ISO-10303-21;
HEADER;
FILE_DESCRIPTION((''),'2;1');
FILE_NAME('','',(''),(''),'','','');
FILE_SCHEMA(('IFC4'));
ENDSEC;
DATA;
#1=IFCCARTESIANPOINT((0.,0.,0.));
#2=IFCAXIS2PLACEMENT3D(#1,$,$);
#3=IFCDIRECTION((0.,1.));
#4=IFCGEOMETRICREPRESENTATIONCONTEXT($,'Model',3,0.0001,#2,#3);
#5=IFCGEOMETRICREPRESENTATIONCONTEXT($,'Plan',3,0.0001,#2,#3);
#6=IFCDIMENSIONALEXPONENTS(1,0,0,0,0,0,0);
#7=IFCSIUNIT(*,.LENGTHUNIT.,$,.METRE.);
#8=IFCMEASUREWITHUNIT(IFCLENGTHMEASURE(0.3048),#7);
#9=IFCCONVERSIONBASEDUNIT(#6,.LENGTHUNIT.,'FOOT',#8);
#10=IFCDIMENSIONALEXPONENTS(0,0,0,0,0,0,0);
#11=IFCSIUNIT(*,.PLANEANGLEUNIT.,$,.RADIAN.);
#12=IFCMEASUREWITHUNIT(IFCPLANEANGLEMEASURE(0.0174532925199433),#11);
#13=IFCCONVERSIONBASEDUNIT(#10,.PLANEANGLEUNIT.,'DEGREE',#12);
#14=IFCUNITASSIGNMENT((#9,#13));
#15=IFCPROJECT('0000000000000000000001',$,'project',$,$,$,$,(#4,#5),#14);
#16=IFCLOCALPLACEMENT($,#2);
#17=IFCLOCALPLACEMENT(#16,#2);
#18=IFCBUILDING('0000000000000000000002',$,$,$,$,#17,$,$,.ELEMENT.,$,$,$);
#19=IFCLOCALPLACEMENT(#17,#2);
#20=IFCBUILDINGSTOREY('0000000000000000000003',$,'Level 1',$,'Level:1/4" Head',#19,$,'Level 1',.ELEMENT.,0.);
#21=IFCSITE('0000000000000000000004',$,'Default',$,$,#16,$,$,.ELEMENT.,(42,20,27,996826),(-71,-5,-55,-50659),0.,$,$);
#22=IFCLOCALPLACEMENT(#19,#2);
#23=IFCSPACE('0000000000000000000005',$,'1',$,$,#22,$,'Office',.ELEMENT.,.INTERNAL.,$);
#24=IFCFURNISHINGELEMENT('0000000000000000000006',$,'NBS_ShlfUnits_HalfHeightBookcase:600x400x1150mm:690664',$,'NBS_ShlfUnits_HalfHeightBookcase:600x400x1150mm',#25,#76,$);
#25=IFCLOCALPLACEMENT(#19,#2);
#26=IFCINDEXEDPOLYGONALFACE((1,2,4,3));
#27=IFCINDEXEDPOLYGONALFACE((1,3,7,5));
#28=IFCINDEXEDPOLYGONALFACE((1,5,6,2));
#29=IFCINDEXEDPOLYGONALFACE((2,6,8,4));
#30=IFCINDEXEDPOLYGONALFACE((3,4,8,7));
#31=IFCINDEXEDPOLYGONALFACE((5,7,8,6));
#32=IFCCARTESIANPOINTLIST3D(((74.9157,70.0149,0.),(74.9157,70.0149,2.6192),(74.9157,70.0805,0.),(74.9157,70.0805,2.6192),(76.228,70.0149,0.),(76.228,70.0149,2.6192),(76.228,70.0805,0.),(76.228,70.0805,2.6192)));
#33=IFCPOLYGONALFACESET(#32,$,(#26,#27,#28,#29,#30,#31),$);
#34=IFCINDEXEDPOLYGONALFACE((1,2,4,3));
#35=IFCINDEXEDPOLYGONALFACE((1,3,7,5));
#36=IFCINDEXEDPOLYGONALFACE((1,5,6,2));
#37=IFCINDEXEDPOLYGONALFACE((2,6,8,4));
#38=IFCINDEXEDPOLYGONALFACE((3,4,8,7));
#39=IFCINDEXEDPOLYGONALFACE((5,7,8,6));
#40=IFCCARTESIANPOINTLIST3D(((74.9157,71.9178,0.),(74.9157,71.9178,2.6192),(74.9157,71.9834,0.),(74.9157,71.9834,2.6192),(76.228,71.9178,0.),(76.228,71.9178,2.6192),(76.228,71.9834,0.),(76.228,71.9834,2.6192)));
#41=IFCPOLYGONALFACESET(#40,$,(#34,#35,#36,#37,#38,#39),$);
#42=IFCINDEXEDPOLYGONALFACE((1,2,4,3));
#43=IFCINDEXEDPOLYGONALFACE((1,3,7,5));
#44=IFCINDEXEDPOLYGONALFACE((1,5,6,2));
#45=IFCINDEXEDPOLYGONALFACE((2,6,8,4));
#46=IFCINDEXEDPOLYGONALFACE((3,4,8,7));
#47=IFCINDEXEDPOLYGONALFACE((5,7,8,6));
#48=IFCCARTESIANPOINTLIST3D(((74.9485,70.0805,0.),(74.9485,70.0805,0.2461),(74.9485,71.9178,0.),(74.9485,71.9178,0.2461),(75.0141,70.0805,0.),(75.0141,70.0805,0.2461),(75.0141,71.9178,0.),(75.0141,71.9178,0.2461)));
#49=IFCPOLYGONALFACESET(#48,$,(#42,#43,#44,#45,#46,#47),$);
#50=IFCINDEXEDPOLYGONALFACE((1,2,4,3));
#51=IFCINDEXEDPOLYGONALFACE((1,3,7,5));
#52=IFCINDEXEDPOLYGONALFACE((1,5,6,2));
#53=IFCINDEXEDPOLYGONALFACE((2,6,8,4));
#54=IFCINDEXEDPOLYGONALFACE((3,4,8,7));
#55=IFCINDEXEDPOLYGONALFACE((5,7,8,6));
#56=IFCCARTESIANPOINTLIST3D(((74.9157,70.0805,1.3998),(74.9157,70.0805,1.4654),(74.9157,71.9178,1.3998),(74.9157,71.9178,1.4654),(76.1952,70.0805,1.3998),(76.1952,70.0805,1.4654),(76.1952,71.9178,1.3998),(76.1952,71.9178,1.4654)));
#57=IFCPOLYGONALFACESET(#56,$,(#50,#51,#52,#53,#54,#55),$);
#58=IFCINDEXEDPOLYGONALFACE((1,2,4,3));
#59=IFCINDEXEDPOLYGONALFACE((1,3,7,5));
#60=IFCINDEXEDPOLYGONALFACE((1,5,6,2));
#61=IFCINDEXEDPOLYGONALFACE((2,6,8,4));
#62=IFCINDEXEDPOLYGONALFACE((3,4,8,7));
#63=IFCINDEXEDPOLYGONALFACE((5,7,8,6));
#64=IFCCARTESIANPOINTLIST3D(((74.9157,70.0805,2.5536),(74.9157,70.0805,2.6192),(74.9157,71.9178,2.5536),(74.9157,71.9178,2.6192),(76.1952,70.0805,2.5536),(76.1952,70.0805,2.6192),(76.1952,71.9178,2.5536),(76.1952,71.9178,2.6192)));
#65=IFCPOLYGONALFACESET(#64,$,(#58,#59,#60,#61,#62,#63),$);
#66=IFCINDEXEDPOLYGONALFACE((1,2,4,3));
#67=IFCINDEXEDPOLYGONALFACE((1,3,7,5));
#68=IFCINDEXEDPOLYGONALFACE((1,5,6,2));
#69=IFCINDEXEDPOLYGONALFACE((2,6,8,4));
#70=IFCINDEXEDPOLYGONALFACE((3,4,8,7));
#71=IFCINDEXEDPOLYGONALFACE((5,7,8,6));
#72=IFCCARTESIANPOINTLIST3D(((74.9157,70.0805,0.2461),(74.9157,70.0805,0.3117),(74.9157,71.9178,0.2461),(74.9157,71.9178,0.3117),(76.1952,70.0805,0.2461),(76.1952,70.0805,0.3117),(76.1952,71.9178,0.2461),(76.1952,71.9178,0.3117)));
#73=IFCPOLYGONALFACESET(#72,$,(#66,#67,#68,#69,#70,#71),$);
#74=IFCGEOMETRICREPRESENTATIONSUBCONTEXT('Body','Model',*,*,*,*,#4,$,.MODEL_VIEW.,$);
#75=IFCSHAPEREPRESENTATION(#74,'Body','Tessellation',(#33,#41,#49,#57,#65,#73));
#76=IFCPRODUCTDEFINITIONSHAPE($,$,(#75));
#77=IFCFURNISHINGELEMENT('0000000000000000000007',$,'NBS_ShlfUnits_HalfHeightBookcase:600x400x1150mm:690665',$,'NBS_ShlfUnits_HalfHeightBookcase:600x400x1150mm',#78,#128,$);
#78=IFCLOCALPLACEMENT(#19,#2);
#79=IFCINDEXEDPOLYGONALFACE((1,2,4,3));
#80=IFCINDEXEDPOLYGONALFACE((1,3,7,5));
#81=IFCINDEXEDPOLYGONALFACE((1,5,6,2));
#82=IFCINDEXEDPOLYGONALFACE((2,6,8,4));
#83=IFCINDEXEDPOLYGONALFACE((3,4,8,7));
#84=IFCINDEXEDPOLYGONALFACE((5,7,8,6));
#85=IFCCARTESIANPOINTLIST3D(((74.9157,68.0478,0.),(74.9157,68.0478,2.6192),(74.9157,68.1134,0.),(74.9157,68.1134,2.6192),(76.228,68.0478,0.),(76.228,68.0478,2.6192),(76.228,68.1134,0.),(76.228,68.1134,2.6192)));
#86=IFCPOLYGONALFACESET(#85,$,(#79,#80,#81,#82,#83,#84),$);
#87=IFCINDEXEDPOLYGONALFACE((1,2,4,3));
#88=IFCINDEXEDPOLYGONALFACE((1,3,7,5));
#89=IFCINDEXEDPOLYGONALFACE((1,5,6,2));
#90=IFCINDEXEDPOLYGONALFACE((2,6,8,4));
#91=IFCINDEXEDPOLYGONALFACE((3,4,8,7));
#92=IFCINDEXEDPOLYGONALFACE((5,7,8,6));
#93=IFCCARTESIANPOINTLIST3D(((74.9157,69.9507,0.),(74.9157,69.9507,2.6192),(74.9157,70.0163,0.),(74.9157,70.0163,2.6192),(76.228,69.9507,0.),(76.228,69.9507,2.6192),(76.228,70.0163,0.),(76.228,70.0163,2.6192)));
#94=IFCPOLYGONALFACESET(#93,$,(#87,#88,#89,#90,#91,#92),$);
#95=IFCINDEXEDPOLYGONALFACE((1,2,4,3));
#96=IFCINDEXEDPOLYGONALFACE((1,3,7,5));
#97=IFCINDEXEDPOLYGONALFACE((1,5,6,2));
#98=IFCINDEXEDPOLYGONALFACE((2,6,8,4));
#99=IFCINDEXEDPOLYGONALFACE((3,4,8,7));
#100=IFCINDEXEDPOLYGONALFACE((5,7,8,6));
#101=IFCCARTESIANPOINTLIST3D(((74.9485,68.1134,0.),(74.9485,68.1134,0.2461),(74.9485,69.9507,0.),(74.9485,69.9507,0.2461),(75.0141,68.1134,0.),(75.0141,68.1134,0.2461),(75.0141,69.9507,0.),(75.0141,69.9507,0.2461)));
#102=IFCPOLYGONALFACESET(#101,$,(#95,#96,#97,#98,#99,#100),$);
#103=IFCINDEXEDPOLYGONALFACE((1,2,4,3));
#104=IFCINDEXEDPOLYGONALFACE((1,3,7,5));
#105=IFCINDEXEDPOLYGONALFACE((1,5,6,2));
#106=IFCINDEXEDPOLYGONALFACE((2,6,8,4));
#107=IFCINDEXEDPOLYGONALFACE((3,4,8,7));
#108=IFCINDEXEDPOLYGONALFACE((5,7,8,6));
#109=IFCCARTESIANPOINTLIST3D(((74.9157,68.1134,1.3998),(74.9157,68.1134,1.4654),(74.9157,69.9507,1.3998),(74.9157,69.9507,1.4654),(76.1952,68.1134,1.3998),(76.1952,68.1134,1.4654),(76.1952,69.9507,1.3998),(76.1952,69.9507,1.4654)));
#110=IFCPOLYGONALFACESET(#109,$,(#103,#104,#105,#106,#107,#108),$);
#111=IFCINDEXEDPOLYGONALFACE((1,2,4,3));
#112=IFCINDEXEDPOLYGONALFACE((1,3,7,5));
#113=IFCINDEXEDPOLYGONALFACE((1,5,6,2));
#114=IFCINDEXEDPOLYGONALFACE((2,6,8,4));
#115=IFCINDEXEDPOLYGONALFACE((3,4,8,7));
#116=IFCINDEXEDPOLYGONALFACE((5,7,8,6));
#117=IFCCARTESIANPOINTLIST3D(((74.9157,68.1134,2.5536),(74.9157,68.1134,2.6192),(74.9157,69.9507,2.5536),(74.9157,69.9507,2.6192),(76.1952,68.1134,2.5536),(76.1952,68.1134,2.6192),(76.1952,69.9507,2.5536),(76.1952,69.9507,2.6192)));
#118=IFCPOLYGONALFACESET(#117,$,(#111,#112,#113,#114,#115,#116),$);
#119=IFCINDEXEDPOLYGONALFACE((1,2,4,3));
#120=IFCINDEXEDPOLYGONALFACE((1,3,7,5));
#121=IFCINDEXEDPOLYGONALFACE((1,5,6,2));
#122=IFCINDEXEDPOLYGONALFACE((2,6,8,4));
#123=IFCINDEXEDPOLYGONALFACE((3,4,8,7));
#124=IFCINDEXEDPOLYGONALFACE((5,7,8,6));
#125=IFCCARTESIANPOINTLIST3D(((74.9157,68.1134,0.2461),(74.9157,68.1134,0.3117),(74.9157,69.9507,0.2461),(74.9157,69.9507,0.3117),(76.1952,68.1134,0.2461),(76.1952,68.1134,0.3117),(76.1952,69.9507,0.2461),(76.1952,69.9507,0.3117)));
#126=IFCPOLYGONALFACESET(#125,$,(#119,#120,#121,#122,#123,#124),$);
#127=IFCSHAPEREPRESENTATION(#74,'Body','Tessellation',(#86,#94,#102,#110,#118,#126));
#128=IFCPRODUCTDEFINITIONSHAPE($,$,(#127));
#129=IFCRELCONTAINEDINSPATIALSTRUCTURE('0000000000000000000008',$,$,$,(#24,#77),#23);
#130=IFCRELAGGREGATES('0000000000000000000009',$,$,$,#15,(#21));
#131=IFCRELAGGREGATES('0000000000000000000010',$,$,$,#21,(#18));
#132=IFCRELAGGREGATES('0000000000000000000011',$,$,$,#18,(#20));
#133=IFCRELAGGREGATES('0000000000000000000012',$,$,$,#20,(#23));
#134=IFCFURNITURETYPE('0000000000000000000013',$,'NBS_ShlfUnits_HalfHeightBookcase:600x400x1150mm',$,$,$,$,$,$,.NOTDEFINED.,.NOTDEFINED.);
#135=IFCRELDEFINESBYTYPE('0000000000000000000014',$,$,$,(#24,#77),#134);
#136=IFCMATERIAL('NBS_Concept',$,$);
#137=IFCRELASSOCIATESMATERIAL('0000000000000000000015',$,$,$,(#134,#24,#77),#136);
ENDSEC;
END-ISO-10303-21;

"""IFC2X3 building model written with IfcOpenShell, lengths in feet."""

from ifc_helpers import new_model, entity, si_unit, converted_unit, direction, frame, frame_2d, origin, origin_2d_with_axis, place, context, subcontext, project, spatial, rectangle, extrude, source, transform, mapped, material, type_object, type_shapes, element, save


model = new_model("IFC2X3")

# Units and contexts
model_context = context("Model", 3, precision=0.0001, world=origin(), true_north=direction((0.0, 1.0)))
plan_context = context("Plan", 3, precision=0.0001, world=origin(), true_north=direction((0.0, 1.0)))
body_context = subcontext(model_context, "Body", "Model", "MODEL_VIEW")
ifc_project = project(units=[converted_unit("LENGTHUNIT", "FOOT", entity("IfcLengthMeasure", 0.3048), si_unit("LENGTHUNIT", "METRE"), dimensions=[1, 0, 0, 0, 0, 0, 0]), converted_unit("PLANEANGLEUNIT", "DEGREE", entity("IfcPlaneAngleMeasure", 0.0174532925199433), si_unit("PLANEANGLEUNIT", "RADIAN"), dimensions=[0, 0, 0, 0, 0, 0, 0])], contexts=[model_context, plan_context])

# Site, building, storey
site_placement = place(None, origin())
site = spatial("IfcSite", under=ifc_project, at=site_placement, Name="Default", CompositionType="ELEMENT", RefLatitude=(42, 20, 27, 996826), RefLongitude=(-71, -5, -55, -50659), RefElevation=0.0)
building_placement = place(site_placement, origin())
building = spatial("IfcBuilding", under=site, at=building_placement, CompositionType="ELEMENT")
storey_placement = place(building_placement, origin())
storey = spatial("IfcBuildingStorey", under=building, at=storey_placement, Name="Level 1", ObjectType="Level:1/4\" Head", LongName="Level 1", CompositionType="ELEMENT", Elevation=0.0)

# Shared definitions
space_1_placement = place(storey_placement, origin())
space_1 = spatial("IfcSpace", under=storey, at=space_1_placement, Name="1", LongName="Office", CompositionType="ELEMENT", InteriorOrExteriorSpace="INTERNAL")

# Furnishing elements
ifc_material_1 = material(Name="NBS_Concept")
furniture_type_1 = type_object("IfcFurnitureType", Name="NBS_ShlfUnits_HalfHeightBookcase:600x400x1150mm", AssemblyPlace="NOTDEFINED", material=ifc_material_1)
shared_shape_1 = source(origin(), body_context, "Body", "SweptSolid", [
    extrude(rectangle(XDim=0.0656, YDim=1.3123, at=origin_2d_with_axis()), frame((0.9514, -0.6562, 0.0), z_axis=(0.0, 0.0, 1.0), x_axis=(-1.0, 0.0, 0.0)), (0.0, 0.0, 1.0), 2.6192),
    extrude(rectangle(XDim=0.0656, YDim=1.3123, at=origin_2d_with_axis()), frame((-0.9514, -0.6562, 0.0), z_axis=(0.0, 0.0, 1.0), x_axis=(-1.0, 0.0, 0.0)), (0.0, 0.0, 1.0), 2.6192),
    extrude(rectangle(XDim=1.8373, YDim=0.0656, at=origin_2d_with_axis()), frame((0.0, -1.2467, 0.0), z_axis=(0.0, 0.0, 1.0), x_axis=(-1.0, 0.0, 0.0)), (0.0, 0.0, 1.0), 0.2461),
    extrude(rectangle(XDim=1.2795, YDim=1.8373, at=frame_2d((0.0, 0.0), x_axis=(1.0, 0.0))), frame((0.0, -0.6726, 1.3998), z_axis=(0.0, 0.0, 1.0), x_axis=(0.0, 1.0, 0.0)), (0.0, 0.0, 1.0), 0.0656),
    extrude(rectangle(XDim=1.2795, YDim=1.8373, at=frame_2d((0.0, 0.0), x_axis=(1.0, 0.0))), frame((0.0, -0.6726, 2.5536), z_axis=(0.0, 0.0, 1.0), x_axis=(0.0, 1.0, 0.0)), (0.0, 0.0, 1.0), 0.0656),
    extrude(rectangle(XDim=1.2795, YDim=1.8373, at=frame_2d((0.0, 0.0), x_axis=(1.0, 0.0))), frame((0.0, -0.6726, 0.2461), z_axis=(0.0, 0.0, 1.0), x_axis=(0.0, 1.0, 0.0)), (0.0, 0.0, 1.0), 0.0656),
])
type_shapes(furniture_type_1, [shared_shape_1])
for number, where, z_axis, x_axis, name in (
    (1, (76.228, 70.9992, 0.0), (0.0, 0.0, 1.0), (0.0, -1.0, 0.0), "NBS_ShlfUnits_HalfHeightBookcase:600x400x1150mm:690664"),
    (2, (76.228, 69.032, 0.0), (0.0, 0.0, 1.0), (0.0, -1.0, 0.0), "NBS_ShlfUnits_HalfHeightBookcase:600x400x1150mm:690665"),
):
    element("IfcFurnishingElement", number, at=place(space_1_placement, frame(where, z_axis=z_axis, x_axis=x_axis)), inside=space_1, type_object=furniture_type_1, material=ifc_material_1, Name=name, ObjectType="NBS_ShlfUnits_HalfHeightBookcase:600x400x1150mm", context=body_context, shape_type="MappedRepresentation", body=[
        mapped(shared_shape_1, transform((0.0, 0.0, 0.0), scale=1.0)),
    ])

save(model, "model.ifc")
